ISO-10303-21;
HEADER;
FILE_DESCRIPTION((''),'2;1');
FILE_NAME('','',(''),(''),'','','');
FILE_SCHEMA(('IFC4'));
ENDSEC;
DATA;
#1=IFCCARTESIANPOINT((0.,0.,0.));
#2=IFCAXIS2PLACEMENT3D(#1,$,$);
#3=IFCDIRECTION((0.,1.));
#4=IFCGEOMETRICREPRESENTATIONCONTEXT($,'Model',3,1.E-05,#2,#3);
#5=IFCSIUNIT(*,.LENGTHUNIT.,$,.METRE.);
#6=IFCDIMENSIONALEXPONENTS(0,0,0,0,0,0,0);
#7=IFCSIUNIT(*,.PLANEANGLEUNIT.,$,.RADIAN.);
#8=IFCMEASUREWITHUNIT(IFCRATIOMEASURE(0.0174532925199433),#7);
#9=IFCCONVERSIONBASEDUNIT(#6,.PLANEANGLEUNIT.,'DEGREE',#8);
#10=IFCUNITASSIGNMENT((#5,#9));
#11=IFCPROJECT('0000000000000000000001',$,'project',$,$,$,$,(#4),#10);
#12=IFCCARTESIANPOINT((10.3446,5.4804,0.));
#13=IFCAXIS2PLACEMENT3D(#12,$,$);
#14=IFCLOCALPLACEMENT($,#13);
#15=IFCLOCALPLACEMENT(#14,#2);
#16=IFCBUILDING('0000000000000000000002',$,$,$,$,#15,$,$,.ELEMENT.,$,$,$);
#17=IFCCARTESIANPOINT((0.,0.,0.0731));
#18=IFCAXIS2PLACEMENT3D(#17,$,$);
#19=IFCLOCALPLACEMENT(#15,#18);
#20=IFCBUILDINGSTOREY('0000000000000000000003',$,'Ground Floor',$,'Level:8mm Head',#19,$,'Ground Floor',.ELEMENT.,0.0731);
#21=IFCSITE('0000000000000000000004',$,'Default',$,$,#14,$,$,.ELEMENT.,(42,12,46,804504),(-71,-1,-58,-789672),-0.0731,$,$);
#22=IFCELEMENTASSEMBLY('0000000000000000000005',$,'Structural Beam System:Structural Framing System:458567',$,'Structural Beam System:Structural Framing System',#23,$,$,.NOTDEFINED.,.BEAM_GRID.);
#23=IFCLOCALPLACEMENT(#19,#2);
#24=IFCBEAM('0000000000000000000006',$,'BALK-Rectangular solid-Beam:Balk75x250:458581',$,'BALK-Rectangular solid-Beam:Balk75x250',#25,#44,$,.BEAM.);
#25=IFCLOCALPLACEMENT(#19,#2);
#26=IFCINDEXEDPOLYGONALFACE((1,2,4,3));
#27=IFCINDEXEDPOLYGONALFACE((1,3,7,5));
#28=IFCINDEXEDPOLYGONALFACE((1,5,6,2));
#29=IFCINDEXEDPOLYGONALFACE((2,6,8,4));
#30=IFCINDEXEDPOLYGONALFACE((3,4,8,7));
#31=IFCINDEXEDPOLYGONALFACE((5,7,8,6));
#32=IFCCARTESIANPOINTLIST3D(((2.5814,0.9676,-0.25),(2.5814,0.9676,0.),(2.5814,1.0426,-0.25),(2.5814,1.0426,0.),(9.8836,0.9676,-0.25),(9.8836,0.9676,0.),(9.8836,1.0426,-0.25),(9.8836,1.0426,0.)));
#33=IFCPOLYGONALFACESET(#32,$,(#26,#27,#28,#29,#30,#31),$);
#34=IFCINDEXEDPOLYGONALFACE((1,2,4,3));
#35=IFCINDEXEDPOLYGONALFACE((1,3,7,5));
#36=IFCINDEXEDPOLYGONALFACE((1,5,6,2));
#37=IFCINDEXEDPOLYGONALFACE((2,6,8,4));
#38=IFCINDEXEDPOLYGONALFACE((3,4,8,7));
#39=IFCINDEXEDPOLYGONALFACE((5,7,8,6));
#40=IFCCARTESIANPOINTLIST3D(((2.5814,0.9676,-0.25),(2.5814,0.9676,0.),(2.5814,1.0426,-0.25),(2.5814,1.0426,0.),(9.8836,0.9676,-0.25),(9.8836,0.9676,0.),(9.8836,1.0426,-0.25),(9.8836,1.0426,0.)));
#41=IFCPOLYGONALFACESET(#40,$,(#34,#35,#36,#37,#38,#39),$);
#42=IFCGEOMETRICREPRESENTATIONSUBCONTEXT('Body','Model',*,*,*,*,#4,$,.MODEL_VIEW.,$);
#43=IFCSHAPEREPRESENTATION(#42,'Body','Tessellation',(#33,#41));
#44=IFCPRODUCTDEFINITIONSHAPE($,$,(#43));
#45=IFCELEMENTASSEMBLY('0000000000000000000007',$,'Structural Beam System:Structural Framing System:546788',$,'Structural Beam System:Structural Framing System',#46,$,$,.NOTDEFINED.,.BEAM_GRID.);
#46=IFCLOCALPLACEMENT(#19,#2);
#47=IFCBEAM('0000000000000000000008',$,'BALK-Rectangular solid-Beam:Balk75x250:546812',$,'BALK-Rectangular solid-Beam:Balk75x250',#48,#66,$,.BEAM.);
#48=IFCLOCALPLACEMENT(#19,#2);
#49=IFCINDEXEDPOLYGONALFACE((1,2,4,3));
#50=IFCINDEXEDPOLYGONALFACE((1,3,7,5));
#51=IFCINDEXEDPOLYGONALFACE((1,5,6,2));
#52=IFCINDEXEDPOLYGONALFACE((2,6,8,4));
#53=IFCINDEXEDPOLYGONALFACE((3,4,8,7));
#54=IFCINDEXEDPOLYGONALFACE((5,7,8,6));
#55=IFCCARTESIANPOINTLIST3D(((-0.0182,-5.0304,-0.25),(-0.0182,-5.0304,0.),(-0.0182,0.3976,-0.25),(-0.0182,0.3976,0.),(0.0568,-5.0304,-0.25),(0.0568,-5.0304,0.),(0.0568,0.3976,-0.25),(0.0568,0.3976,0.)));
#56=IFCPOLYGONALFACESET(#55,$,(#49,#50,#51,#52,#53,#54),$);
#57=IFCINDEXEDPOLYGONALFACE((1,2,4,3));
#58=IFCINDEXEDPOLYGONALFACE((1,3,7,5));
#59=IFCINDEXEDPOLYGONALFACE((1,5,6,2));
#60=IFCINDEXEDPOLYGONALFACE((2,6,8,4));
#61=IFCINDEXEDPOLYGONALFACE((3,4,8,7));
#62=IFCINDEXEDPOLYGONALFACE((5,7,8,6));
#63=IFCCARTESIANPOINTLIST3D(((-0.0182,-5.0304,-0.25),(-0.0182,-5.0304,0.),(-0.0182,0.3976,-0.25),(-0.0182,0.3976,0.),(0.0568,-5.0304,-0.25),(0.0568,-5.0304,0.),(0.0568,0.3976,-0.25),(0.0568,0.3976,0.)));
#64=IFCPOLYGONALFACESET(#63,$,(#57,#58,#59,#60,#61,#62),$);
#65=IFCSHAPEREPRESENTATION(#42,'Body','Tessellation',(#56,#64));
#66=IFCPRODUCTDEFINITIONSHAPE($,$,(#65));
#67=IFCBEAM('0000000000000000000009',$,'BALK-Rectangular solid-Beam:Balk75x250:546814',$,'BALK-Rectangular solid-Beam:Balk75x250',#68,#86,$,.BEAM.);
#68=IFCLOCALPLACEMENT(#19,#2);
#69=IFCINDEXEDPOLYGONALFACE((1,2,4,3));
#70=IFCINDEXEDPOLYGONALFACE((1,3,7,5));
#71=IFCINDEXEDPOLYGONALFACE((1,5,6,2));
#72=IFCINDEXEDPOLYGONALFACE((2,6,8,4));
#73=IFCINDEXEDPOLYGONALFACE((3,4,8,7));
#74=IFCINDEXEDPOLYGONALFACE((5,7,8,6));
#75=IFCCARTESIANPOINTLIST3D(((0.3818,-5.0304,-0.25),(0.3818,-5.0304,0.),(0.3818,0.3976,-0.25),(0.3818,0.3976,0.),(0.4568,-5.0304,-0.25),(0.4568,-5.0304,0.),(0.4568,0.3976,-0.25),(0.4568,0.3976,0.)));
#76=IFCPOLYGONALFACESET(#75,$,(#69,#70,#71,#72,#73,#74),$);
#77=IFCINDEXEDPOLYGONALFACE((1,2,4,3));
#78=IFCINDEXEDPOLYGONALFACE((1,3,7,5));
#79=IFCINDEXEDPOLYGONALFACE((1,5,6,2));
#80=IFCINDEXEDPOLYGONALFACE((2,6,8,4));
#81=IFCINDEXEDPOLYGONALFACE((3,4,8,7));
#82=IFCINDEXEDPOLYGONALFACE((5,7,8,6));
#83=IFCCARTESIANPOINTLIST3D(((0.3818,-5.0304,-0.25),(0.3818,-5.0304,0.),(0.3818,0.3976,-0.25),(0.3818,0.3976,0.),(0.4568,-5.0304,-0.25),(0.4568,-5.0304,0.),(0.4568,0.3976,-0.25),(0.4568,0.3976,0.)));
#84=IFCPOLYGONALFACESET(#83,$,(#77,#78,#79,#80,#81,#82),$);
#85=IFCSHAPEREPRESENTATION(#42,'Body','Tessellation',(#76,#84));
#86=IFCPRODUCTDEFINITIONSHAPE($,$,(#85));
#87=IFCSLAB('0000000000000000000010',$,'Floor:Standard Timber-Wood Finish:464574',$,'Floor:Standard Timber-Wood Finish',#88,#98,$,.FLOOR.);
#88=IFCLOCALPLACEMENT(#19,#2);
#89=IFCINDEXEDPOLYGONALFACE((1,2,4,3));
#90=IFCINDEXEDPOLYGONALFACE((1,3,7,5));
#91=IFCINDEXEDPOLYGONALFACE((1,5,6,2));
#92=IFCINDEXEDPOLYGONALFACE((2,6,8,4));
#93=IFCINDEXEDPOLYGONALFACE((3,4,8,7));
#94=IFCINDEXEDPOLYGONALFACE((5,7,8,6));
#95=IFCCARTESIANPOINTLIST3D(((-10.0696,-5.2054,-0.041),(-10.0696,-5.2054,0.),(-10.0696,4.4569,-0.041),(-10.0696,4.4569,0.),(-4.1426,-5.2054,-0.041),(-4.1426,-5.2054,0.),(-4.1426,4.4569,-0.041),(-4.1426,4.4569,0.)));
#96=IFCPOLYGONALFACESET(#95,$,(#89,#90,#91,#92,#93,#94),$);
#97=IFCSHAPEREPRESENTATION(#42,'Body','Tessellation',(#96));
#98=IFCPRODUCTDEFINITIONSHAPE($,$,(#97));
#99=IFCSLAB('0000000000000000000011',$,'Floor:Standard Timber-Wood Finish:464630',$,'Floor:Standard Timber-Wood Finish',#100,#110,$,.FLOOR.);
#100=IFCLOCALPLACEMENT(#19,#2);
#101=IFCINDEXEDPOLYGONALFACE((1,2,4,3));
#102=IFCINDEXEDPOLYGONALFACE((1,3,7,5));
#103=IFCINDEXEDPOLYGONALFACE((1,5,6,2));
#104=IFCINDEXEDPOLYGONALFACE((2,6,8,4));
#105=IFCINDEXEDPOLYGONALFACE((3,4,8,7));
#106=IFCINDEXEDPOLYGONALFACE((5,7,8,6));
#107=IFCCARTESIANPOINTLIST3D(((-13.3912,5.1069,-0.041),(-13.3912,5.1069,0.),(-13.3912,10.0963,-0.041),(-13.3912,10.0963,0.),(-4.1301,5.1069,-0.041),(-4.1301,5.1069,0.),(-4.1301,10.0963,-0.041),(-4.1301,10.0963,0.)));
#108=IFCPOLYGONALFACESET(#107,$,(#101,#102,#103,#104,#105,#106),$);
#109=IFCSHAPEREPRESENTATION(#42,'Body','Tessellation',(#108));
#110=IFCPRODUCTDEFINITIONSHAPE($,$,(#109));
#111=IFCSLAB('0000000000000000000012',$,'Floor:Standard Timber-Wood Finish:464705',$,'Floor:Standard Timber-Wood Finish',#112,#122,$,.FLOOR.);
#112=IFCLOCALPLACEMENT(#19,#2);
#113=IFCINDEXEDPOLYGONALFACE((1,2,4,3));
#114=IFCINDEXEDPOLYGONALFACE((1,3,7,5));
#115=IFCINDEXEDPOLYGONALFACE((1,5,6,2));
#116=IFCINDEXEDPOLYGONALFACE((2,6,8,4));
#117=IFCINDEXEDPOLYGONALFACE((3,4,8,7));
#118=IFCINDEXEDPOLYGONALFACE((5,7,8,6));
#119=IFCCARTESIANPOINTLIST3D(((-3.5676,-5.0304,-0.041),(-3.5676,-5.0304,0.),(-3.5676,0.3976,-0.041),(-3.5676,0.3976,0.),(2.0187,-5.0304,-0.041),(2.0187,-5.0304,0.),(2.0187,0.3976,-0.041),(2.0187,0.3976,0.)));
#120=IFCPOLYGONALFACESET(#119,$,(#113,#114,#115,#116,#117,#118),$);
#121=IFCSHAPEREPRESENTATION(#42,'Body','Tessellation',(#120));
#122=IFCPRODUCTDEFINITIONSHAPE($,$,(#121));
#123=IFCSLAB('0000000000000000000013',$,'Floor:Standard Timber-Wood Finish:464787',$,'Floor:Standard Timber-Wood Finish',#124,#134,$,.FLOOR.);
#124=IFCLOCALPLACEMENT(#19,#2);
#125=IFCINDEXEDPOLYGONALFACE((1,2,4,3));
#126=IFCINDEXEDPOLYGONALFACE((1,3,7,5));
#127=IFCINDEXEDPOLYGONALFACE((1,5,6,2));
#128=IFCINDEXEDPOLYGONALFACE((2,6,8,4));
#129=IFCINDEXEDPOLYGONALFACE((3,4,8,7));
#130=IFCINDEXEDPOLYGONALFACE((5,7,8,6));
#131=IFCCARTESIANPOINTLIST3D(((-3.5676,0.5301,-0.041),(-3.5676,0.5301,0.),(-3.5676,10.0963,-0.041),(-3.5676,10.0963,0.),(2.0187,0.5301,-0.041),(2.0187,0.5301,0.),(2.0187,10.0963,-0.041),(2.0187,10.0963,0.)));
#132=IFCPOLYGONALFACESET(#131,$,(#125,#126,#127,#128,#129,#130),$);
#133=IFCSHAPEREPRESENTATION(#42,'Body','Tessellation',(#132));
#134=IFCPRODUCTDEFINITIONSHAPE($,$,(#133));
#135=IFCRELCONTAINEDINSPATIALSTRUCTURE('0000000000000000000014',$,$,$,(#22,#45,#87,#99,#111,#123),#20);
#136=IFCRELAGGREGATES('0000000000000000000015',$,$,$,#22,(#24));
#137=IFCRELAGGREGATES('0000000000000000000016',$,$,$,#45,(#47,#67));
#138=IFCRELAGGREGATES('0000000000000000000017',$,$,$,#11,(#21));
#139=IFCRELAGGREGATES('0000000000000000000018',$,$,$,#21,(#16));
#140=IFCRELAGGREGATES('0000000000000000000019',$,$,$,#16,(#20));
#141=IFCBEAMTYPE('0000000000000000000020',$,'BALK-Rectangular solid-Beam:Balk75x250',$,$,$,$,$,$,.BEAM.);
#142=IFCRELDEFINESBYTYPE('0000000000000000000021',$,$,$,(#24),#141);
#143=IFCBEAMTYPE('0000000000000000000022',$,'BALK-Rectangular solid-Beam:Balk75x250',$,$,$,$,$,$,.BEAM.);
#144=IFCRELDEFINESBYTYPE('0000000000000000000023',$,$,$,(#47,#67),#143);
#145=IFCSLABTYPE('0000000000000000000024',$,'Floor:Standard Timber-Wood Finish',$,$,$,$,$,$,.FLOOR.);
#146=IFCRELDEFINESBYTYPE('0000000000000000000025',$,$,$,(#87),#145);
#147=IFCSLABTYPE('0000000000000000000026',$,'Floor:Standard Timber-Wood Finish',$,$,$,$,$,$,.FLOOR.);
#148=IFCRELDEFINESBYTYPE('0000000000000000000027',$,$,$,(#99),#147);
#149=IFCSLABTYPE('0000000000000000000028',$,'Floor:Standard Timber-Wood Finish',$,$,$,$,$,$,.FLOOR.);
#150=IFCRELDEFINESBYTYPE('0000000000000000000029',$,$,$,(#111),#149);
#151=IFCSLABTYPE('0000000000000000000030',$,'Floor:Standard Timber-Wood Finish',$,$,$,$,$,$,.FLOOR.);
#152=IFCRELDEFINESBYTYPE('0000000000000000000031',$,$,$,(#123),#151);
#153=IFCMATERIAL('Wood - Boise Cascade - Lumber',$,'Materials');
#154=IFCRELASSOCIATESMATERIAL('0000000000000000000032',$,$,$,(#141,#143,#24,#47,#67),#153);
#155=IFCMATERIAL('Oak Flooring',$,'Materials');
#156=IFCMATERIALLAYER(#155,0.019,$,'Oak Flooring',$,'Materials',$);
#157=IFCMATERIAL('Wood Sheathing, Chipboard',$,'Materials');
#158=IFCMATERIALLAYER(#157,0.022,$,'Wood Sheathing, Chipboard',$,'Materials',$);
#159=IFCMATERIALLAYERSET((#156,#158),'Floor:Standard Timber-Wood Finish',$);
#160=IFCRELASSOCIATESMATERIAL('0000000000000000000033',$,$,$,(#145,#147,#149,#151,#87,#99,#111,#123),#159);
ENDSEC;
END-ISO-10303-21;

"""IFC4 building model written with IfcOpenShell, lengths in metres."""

from ifc_helpers import new_model, entity, si_unit, converted_unit, direction, frame, frame_2d, origin, origin_2d_with_axis, place, context, subcontext, project, spatial, rectangle, extrude, source, transform, mapped, material, layer, layer_set, layer_usage, material_profile, profile_set, profile_usage, type_object, type_shapes, element, aggregate, save


model = new_model("IFC4")

# Units and contexts
model_context = context("Model", 3, precision=1e-05, world=origin(), true_north=direction((0.0, 1.0)))
body_context = subcontext(model_context, "Body", "Model", "MODEL_VIEW")
ifc_project = project(units=[si_unit("LENGTHUNIT", "METRE"), converted_unit("PLANEANGLEUNIT", "DEGREE", entity("IfcRatioMeasure", 0.0174532925199433), si_unit("PLANEANGLEUNIT", "RADIAN"), dimensions=[0, 0, 0, 0, 0, 0, 0])], contexts=[model_context])

# Site, building, storey
site_placement = place(None, frame((10.3446, 5.4804, 0.0)))
site = spatial("IfcSite", under=ifc_project, at=site_placement, Name="Default", CompositionType="ELEMENT", RefLatitude=(42, 12, 46, 804504), RefLongitude=(-71, -1, -58, -789672), RefElevation=-0.0731)
building_placement = place(site_placement, origin())
building = spatial("IfcBuilding", under=site, at=building_placement, CompositionType="ELEMENT")
storey_placement = place(building_placement, frame((0.0, 0.0, 0.0731)))
storey = spatial("IfcBuildingStorey", under=building, at=storey_placement, Name="Ground Floor", ObjectType="Level:8mm Head", LongName="Ground Floor", CompositionType="ELEMENT", Elevation=0.0731)

# Element assemblies, beams
ifc_material_1 = material(Name="Wood - Boise Cascade - Lumber", Category="Materials")
ifc_material_profile = material_profile(ifc_material_1, rectangle(XDim=0.25, YDim=0.075, at=frame_2d((0.0, 0.0), x_axis=(1.0, 0.0))), Name="Balk75x250")
ifc_profile_set = profile_set([ifc_material_profile], Name="Balk75x250")
assembly_1_placement = place(storey_placement, origin())
assembly_1 = element("IfcElementAssembly", 1, at=assembly_1_placement, inside=storey, Name="Structural Beam System:Structural Framing System:458567", ObjectType="Structural Beam System:Structural Framing System", AssemblyPlace="NOTDEFINED", PredefinedType="BEAM_GRID")
ifc_profile_usage_1 = profile_usage(ifc_profile_set, cardinal=8)
beam_type_1 = type_object("IfcBeamType", Name="BALK-Rectangular solid-Beam:Balk75x250", PredefinedType="BEAM", material=ifc_profile_set)
shared_shape_1 = source(origin(), body_context, "Body", "SweptSolid", [
    extrude(rectangle(XDim=0.25, YDim=0.075, at=frame_2d((0.0, 0.0), x_axis=(1.0, 0.0))), frame((2.5814, 1.0051, -0.0519), z_axis=(1.0, 0.0, 0.0), x_axis=(0.0, 0.0, -1.0)), (0.0, 0.0, 1.0), 7.3022),
    extrude(rectangle(XDim=0.25, YDim=0.075, at=frame_2d((0.0, 0.0), x_axis=(1.0, 0.0))), frame((2.5814, 1.0051, -0.0519), z_axis=(1.0, 0.0, 0.0), x_axis=(0.0, 0.0, -1.0)), (0.0, 0.0, 1.0), 7.3022),
])
type_shapes(beam_type_1, [shared_shape_1])
beam_1_placement = place(assembly_1_placement, frame((0.0, 0.0, -0.0731)))
beam_1 = element("IfcBeam", 2, at=beam_1_placement, type_object=beam_type_1, material=ifc_profile_usage_1, Name="BALK-Rectangular solid-Beam:Balk75x250:458581", ObjectType="BALK-Rectangular solid-Beam:Balk75x250", PredefinedType="BEAM", context=body_context, shape_type="MappedRepresentation", body=[
    mapped(shared_shape_1, transform((0.0, 0.0, 0.0), scale=1.0)),
])
aggregate(assembly_1, [beam_1])
assembly_2_placement = place(storey_placement, origin())
assembly_2 = element("IfcElementAssembly", 3, at=assembly_2_placement, inside=storey, Name="Structural Beam System:Structural Framing System:546788", ObjectType="Structural Beam System:Structural Framing System", AssemblyPlace="NOTDEFINED", PredefinedType="BEAM_GRID")
ifc_profile_usage_2 = profile_usage(ifc_profile_set, cardinal=8)
beam_type_2 = type_object("IfcBeamType", Name="BALK-Rectangular solid-Beam:Balk75x250", PredefinedType="BEAM", material=ifc_profile_set)
shared_shape_2 = source(origin(), body_context, "Body", "SweptSolid", [
    extrude(rectangle(XDim=0.25, YDim=0.075, at=origin_2d_with_axis()), frame((-2.5203, 0.0, 0.0), z_axis=(1.0, 0.0, 0.0), x_axis=(0.0, 0.0, -1.0)), (0.0, 0.0, 1.0), 5.428),
    extrude(rectangle(XDim=0.25, YDim=0.075, at=origin_2d_with_axis()), frame((-2.5203, 0.0, 0.0), z_axis=(1.0, 0.0, 0.0), x_axis=(0.0, 0.0, -1.0)), (0.0, 0.0, 1.0), 5.428),
])
type_shapes(beam_type_2, [shared_shape_2])
beam_2_placement = place(assembly_2_placement, frame((0.0193, -2.5102, -0.125), z_axis=(0.0, 0.0, 1.0), x_axis=(0.0, 1.0, 0.0)))
beam_2 = element("IfcBeam", 4, at=beam_2_placement, type_object=beam_type_2, material=ifc_profile_usage_2, Name="BALK-Rectangular solid-Beam:Balk75x250:546812", ObjectType="BALK-Rectangular solid-Beam:Balk75x250", PredefinedType="BEAM", context=body_context, shape_type="MappedRepresentation", body=[
    mapped(shared_shape_2, transform((0.0, 0.0, 0.0), scale=1.0)),
])
ifc_profile_usage_3 = profile_usage(ifc_profile_set, cardinal=8)
beam_3_placement = place(assembly_2_placement, frame((0.4193, -2.5102, -0.125), z_axis=(0.0, 0.0, 1.0), x_axis=(0.0, 1.0, 0.0)))
beam_3 = element("IfcBeam", 5, at=beam_3_placement, type_object=beam_type_2, material=ifc_profile_usage_3, Name="BALK-Rectangular solid-Beam:Balk75x250:546814", ObjectType="BALK-Rectangular solid-Beam:Balk75x250", PredefinedType="BEAM", context=body_context, shape_type="MappedRepresentation", body=[
    mapped(shared_shape_2, transform((0.0, 0.0, 0.0), scale=1.0)),
])
aggregate(assembly_2, [beam_2, beam_3])

# Slabs
ifc_material_2 = material(Name="Oak Flooring", Category="Materials")
ifc_layer_1 = layer(ifc_material_2, 0.019, Name="Oak Flooring", Category="Materials")
ifc_material_3 = material(Name="Wood Sheathing, Chipboard", Category="Materials")
ifc_layer_2 = layer(ifc_material_3, 0.022, Name="Wood Sheathing, Chipboard", Category="Materials")
ifc_layer_set = layer_set([ifc_layer_1, ifc_layer_2], Name="Floor:Standard Timber-Wood Finish")
ifc_layer_usage_1 = layer_usage(ifc_layer_set, "AXIS3", "POSITIVE", 0.0)
slab_type_1 = type_object("IfcSlabType", Name="Floor:Standard Timber-Wood Finish", PredefinedType="FLOOR", material=ifc_layer_set)
slab_1_placement = place(storey_placement, origin())
element("IfcSlab", 6, at=slab_1_placement, inside=storey, type_object=slab_type_1, material=ifc_layer_usage_1, Name="Floor:Standard Timber-Wood Finish:464574", ObjectType="Floor:Standard Timber-Wood Finish", PredefinedType="FLOOR", context=body_context, shape_type="SweptSolid", body=[
    extrude(rectangle(XDim=9.6623, YDim=5.927, at=frame_2d((0.0, 0.0), x_axis=(1.0, 0.0))), frame((-7.1061, -0.3743, 0.0), z_axis=(0.0, 0.0, -1.0), x_axis=(0.0, 1.0, 0.0)), (0.0, 0.0, 1.0), 0.041),
])
ifc_layer_usage_2 = layer_usage(ifc_layer_set, "AXIS3", "POSITIVE", 0.0)
slab_type_2 = type_object("IfcSlabType", Name="Floor:Standard Timber-Wood Finish", PredefinedType="FLOOR", material=ifc_layer_set)
slab_2_placement = place(storey_placement, origin())
element("IfcSlab", 7, at=slab_2_placement, inside=storey, type_object=slab_type_2, material=ifc_layer_usage_2, Name="Floor:Standard Timber-Wood Finish:464630", ObjectType="Floor:Standard Timber-Wood Finish", PredefinedType="FLOOR", context=body_context, shape_type="SweptSolid", body=[
    extrude(rectangle(XDim=4.9894, YDim=9.2611, at=origin_2d_with_axis()), frame((-8.7607, 7.6016, 0.0), z_axis=(0.0, 0.0, -1.0), x_axis=(0.0, 1.0, 0.0)), (0.0, 0.0, 1.0), 0.041),
])
ifc_layer_usage_3 = layer_usage(ifc_layer_set, "AXIS3", "POSITIVE", 0.0)
slab_type_3 = type_object("IfcSlabType", Name="Floor:Standard Timber-Wood Finish", PredefinedType="FLOOR", material=ifc_layer_set)
slab_3_placement = place(storey_placement, origin())
element("IfcSlab", 8, at=slab_3_placement, inside=storey, type_object=slab_type_3, material=ifc_layer_usage_3, Name="Floor:Standard Timber-Wood Finish:464705", ObjectType="Floor:Standard Timber-Wood Finish", PredefinedType="FLOOR", context=body_context, shape_type="SweptSolid", body=[
    extrude(rectangle(XDim=5.428, YDim=5.5863, at=frame_2d((0.0, 0.0), x_axis=(1.0, 0.0))), frame((-0.7745, -2.3164, 0.0), z_axis=(0.0, 0.0, -1.0), x_axis=(0.0, 1.0, 0.0)), (0.0, 0.0, 1.0), 0.041),
])
ifc_layer_usage_4 = layer_usage(ifc_layer_set, "AXIS3", "POSITIVE", 0.0)
slab_type_4 = type_object("IfcSlabType", Name="Floor:Standard Timber-Wood Finish", PredefinedType="FLOOR", material=ifc_layer_set)
slab_4_placement = place(storey_placement, origin())
element("IfcSlab", 9, at=slab_4_placement, inside=storey, type_object=slab_type_4, material=ifc_layer_usage_4, Name="Floor:Standard Timber-Wood Finish:464787", ObjectType="Floor:Standard Timber-Wood Finish", PredefinedType="FLOOR", context=body_context, shape_type="SweptSolid", body=[
    extrude(rectangle(XDim=9.5662, YDim=5.5863, at=frame_2d((0.0, 0.0), x_axis=(1.0, 0.0))), frame((-0.7745, 5.3132, 0.0), z_axis=(0.0, 0.0, -1.0), x_axis=(0.0, 1.0, 0.0)), (0.0, 0.0, 1.0), 0.041),
])

save(model, "model.ifc")
